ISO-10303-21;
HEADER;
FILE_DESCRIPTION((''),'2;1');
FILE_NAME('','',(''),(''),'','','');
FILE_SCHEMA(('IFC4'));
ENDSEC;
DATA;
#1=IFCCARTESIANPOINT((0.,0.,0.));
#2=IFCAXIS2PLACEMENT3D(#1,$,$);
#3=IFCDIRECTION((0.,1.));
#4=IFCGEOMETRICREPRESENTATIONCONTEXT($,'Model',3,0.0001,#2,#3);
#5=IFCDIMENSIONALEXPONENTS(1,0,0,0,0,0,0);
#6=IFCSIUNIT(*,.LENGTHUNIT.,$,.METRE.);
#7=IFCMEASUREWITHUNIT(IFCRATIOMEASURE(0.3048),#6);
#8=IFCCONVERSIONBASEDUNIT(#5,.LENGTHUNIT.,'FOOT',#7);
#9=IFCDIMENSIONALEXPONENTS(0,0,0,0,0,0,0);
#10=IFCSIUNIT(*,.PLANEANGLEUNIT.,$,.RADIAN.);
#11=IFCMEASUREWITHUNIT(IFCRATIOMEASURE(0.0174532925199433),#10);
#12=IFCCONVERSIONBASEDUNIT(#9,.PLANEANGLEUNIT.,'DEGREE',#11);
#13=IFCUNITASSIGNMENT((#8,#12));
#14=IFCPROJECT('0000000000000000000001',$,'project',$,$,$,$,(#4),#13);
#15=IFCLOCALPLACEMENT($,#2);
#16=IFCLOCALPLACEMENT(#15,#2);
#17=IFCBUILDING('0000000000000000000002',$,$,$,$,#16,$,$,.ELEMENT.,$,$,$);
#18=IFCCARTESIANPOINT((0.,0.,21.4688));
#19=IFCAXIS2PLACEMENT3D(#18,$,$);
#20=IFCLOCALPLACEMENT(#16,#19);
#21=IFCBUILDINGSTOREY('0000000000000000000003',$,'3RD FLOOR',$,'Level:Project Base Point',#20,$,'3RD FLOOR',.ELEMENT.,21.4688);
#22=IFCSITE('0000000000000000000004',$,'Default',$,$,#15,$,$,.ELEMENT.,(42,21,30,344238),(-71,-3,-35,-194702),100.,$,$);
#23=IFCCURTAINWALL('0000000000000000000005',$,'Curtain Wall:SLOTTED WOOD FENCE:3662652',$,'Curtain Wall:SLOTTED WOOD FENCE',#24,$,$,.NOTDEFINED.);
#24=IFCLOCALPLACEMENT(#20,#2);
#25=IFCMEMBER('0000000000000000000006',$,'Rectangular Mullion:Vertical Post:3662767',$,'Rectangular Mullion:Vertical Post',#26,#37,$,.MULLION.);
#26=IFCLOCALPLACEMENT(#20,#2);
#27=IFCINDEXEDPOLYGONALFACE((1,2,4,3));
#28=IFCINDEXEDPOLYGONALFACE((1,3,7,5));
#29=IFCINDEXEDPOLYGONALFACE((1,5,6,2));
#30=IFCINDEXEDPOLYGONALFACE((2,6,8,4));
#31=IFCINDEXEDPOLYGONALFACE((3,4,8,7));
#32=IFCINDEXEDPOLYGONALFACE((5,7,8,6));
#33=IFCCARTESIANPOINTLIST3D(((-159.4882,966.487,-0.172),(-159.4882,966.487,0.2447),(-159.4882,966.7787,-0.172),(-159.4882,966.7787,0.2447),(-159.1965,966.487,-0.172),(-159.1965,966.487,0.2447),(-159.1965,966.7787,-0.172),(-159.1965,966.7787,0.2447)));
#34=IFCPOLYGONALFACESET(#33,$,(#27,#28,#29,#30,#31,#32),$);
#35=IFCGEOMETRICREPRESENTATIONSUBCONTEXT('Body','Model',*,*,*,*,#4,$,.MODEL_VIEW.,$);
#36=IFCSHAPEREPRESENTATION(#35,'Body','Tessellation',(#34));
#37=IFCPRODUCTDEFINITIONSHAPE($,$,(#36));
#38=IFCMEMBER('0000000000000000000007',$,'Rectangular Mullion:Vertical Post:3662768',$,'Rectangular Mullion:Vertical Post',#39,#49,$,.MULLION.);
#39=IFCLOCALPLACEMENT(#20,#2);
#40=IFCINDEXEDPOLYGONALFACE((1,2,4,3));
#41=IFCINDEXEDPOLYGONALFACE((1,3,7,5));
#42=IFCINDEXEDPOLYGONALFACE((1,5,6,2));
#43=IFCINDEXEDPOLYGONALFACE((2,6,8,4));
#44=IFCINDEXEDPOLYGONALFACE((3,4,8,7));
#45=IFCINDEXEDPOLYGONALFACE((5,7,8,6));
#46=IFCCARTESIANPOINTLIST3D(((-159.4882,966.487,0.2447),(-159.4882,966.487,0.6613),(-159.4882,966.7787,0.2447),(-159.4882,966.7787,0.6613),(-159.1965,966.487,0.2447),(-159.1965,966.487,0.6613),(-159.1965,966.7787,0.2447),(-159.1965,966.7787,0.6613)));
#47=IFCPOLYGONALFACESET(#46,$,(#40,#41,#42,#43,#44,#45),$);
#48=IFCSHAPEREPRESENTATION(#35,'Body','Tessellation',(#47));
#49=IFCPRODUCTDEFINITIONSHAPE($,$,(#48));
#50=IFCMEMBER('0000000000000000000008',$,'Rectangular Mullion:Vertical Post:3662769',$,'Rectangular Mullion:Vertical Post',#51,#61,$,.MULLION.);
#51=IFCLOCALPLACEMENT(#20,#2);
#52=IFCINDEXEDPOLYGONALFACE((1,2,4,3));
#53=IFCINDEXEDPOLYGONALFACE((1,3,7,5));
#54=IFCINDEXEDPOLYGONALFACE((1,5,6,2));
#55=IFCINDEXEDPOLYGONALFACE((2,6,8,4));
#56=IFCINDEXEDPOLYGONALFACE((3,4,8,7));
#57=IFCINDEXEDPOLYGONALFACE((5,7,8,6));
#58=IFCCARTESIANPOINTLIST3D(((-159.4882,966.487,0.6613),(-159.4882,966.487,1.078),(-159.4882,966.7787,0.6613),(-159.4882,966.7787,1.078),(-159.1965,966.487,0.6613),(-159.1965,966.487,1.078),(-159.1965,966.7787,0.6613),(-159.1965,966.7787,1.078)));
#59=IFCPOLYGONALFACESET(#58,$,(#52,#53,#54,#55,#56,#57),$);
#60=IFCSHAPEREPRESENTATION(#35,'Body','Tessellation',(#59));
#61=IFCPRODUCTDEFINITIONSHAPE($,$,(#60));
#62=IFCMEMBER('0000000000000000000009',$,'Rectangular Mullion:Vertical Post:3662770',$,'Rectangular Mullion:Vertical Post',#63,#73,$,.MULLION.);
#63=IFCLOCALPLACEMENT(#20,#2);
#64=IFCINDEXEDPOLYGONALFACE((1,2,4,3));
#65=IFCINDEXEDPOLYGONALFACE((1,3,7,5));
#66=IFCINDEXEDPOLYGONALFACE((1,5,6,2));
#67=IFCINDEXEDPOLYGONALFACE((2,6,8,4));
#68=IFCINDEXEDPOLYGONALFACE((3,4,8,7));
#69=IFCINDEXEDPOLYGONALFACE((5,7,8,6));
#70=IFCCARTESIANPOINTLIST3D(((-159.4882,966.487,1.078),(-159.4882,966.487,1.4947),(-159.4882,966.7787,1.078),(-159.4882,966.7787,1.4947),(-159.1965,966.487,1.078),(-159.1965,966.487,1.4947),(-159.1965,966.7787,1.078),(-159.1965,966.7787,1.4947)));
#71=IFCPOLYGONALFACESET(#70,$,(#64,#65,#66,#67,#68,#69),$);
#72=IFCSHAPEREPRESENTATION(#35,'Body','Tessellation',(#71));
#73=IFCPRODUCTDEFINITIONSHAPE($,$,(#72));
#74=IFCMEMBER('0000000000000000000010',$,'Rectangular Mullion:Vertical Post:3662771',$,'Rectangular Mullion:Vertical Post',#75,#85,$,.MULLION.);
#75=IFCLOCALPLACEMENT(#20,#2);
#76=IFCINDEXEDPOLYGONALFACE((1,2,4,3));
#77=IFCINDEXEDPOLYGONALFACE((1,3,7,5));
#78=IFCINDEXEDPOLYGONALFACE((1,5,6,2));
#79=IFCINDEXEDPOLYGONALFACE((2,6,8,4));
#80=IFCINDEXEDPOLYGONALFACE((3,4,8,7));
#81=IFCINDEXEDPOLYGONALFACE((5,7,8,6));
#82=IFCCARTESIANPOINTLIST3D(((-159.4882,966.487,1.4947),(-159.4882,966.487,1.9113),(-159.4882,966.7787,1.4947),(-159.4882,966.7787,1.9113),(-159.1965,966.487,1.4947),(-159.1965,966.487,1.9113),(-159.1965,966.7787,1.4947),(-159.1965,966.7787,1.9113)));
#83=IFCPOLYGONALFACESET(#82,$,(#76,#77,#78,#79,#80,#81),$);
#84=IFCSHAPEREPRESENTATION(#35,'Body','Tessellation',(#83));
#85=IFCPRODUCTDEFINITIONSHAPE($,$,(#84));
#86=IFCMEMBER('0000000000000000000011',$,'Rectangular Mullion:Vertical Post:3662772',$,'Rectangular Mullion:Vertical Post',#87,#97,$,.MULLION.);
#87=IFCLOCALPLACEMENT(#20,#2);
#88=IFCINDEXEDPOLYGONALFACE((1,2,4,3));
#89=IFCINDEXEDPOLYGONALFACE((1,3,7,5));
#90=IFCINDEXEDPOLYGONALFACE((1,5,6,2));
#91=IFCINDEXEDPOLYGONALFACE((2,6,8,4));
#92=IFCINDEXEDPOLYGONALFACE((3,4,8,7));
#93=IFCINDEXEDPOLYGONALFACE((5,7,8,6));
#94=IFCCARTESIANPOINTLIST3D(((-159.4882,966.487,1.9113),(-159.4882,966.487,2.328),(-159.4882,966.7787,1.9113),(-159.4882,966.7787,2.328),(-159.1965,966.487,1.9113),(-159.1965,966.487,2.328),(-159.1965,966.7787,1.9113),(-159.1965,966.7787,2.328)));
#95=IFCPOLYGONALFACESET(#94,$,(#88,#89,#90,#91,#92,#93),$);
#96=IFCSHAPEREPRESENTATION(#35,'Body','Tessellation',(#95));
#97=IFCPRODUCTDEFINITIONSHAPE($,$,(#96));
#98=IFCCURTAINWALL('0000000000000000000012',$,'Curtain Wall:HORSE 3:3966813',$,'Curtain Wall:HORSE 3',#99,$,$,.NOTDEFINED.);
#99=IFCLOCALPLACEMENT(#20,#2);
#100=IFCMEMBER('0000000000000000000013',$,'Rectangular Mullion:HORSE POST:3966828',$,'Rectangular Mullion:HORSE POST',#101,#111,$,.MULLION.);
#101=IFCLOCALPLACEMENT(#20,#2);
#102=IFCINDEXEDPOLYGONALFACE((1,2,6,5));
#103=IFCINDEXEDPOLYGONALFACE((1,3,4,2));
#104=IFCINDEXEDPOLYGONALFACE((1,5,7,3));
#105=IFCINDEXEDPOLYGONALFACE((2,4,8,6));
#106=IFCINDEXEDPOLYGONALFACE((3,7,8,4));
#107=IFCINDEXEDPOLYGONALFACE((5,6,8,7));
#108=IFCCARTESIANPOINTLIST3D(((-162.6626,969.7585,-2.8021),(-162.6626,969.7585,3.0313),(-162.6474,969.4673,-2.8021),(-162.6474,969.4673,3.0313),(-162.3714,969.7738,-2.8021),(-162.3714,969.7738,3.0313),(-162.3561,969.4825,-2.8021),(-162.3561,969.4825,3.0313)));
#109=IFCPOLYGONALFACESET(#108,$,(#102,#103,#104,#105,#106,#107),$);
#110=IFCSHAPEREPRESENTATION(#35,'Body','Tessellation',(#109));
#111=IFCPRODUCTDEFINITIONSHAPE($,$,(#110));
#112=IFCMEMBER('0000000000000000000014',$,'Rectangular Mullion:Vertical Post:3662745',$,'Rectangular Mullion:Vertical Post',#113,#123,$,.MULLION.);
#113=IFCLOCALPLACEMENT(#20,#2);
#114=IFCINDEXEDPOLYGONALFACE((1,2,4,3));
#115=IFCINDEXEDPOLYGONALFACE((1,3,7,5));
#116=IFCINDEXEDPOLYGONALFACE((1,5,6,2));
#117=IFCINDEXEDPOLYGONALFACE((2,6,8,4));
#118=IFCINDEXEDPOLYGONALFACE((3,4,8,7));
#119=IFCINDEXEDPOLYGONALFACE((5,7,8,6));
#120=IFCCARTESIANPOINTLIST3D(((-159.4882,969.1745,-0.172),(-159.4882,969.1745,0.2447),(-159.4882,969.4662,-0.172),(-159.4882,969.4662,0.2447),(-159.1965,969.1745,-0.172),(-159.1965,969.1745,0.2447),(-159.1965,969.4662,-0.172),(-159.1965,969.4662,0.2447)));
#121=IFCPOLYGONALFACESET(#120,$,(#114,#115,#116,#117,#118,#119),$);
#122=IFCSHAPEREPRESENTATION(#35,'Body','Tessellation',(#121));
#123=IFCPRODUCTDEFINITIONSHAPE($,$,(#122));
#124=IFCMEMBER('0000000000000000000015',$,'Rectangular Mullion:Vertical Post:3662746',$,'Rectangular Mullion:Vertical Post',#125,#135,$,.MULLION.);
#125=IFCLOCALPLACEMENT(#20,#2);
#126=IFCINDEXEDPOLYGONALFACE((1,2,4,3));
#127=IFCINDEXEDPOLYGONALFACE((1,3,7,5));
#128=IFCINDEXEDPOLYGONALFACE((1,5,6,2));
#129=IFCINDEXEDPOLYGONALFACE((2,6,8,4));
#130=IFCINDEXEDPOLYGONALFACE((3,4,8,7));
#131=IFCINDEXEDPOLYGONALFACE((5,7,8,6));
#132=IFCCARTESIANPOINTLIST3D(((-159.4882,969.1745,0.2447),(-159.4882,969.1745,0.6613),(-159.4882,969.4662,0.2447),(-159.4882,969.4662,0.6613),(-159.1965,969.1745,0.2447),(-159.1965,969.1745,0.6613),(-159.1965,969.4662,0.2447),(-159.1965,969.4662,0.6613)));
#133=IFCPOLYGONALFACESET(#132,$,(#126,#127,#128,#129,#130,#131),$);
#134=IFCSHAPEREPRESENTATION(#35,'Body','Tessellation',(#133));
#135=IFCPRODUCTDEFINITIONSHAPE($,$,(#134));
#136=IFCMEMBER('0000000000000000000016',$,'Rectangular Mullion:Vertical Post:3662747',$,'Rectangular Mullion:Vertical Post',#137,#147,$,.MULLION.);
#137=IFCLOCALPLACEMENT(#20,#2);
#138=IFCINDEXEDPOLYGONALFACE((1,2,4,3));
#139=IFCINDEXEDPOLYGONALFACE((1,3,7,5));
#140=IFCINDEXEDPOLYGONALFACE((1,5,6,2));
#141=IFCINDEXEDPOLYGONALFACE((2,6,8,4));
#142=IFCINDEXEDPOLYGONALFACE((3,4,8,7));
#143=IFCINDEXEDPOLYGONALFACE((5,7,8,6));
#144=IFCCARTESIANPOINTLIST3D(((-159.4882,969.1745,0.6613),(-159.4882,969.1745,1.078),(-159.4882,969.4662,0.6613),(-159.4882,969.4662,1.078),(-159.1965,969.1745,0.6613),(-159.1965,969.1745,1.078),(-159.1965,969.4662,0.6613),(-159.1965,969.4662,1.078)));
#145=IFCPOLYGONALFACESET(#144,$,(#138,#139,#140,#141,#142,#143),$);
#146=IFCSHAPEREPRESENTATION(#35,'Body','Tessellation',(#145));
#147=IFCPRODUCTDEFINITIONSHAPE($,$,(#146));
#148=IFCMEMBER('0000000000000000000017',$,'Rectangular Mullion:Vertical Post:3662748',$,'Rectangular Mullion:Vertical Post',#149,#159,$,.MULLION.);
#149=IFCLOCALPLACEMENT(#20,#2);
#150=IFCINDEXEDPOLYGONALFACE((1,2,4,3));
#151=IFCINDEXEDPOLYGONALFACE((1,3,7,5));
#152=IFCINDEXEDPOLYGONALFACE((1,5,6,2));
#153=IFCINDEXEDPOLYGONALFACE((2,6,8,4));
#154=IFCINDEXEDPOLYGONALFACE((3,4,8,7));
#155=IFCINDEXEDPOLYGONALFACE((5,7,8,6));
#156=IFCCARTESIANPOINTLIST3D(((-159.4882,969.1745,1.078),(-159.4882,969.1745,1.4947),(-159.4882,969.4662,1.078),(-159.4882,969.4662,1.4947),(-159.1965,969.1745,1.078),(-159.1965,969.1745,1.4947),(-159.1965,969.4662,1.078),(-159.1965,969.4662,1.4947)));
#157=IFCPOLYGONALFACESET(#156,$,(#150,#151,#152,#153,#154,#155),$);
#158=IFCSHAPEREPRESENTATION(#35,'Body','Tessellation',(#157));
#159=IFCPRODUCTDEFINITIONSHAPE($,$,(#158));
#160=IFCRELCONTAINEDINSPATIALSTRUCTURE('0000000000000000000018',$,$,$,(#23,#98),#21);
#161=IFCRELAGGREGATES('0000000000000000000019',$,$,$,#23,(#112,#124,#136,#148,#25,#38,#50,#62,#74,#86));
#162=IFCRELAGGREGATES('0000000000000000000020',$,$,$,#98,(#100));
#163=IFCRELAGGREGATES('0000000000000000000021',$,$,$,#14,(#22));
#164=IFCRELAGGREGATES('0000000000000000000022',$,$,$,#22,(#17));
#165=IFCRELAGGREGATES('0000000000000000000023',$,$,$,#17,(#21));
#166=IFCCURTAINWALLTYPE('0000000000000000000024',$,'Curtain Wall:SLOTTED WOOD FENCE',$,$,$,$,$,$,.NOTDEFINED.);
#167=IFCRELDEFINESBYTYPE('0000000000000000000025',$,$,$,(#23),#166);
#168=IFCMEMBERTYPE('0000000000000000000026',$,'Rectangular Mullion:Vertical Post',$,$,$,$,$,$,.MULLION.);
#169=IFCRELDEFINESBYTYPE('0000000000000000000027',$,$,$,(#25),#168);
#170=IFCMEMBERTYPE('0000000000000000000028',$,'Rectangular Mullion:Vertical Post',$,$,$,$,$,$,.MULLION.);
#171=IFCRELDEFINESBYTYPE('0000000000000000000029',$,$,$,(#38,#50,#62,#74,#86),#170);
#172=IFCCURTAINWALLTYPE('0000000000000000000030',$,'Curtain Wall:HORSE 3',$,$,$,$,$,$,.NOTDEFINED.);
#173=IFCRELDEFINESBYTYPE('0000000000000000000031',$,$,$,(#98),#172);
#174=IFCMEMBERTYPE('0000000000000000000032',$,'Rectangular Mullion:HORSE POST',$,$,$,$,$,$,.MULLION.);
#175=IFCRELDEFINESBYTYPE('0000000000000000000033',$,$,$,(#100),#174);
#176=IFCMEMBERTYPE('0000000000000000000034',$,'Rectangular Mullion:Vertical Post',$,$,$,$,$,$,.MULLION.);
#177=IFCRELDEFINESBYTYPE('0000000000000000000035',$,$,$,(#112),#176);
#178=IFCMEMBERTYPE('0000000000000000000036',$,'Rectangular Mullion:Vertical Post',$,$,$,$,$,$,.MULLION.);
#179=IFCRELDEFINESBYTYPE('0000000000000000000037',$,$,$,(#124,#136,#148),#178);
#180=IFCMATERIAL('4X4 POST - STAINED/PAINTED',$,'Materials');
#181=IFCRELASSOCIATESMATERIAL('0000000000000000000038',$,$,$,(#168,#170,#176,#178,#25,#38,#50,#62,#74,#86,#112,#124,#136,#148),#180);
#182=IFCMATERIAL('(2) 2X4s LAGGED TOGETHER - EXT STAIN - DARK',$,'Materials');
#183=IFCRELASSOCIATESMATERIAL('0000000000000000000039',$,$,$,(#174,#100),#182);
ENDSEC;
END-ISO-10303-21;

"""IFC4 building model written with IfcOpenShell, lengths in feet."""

from ifc_helpers import new_model, entity, si_unit, converted_unit, direction, frame, frame_2d, origin, origin_2d_with_axis, place, context, subcontext, project, spatial, rectangle, extrude, source, transform, mapped, material, material_profile, profile_set, profile_usage, type_object, type_shapes, element, aggregate, save


model = new_model("IFC4")

# Units and contexts
model_context = context("Model", 3, precision=0.0001, world=origin(), true_north=direction((0.0, 1.0)))
body_context = subcontext(model_context, "Body", "Model", "MODEL_VIEW")
ifc_project = project(units=[converted_unit("LENGTHUNIT", "FOOT", entity("IfcRatioMeasure", 0.3048), si_unit("LENGTHUNIT", "METRE"), dimensions=[1, 0, 0, 0, 0, 0, 0]), converted_unit("PLANEANGLEUNIT", "DEGREE", entity("IfcRatioMeasure", 0.0174532925199433), si_unit("PLANEANGLEUNIT", "RADIAN"), dimensions=[0, 0, 0, 0, 0, 0, 0])], contexts=[model_context])

# Site, building, storey
site_placement = place(None, origin())
site = spatial("IfcSite", under=ifc_project, at=site_placement, Name="Default", CompositionType="ELEMENT", RefLatitude=(42, 21, 30, 344238), RefLongitude=(-71, -3, -35, -194702), RefElevation=100.0)
building_placement = place(site_placement, origin())
building = spatial("IfcBuilding", under=site, at=building_placement, CompositionType="ELEMENT")
storey_placement = place(building_placement, frame((0.0, 0.0, 21.4688)))
storey = spatial("IfcBuildingStorey", under=building, at=storey_placement, Name="3RD FLOOR", ObjectType="Level:Project Base Point", LongName="3RD FLOOR", CompositionType="ELEMENT", Elevation=21.4688)

# Curtain wall, members
curtain_wall_type_1 = type_object("IfcCurtainWallType", Name="Curtain Wall:SLOTTED WOOD FENCE", PredefinedType="NOTDEFINED")
curtain_wall_1_placement = place(storey_placement, frame((0.0, 0.0, -21.4688)))
curtain_wall_1 = element("IfcCurtainWall", 1, at=curtain_wall_1_placement, inside=storey, type_object=curtain_wall_type_1, Name="Curtain Wall:SLOTTED WOOD FENCE:3662652", ObjectType="Curtain Wall:SLOTTED WOOD FENCE", PredefinedType="NOTDEFINED")
ifc_material_1 = material(Name="4X4 POST - STAINED/PAINTED", Category="Materials")
ifc_material_profile_1 = material_profile(ifc_material_1, rectangle(XDim=0.2917, YDim=0.2917, at=origin_2d_with_axis()), Name="Vertical Post")
ifc_profile_set_1 = profile_set([ifc_material_profile_1], Name="Vertical Post")
ifc_profile_usage_1 = profile_usage(ifc_profile_set_1)
member_type_1 = type_object("IfcMemberType", Name="Rectangular Mullion:Vertical Post", PredefinedType="MULLION", material=ifc_profile_set_1)
shared_shape_1 = source(origin(), body_context, "Body", "SweptSolid", [
    extrude(rectangle(XDim=0.2917, YDim=0.2917, at=origin_2d_with_axis()), frame((0.0, -0.2083, -0.4167), z_axis=(0.0, 0.0, 1.0), x_axis=(0.0, -1.0, 0.0)), (0.0, 0.0, 1.0), 0.4167),
])
type_shapes(member_type_1, [shared_shape_1])
member_1_placement = place(storey_placement, frame((-159.5507, 966.6328, -0.172), z_axis=(0.0, 0.0, -1.0), x_axis=(0.0, -1.0, 0.0)))
member_1 = element("IfcMember", 2, at=member_1_placement, type_object=member_type_1, material=ifc_profile_usage_1, Name="Rectangular Mullion:Vertical Post:3662767", ObjectType="Rectangular Mullion:Vertical Post", PredefinedType="MULLION", context=body_context, shape_type="MappedRepresentation", body=[
    mapped(shared_shape_1, transform((0.0, 0.0, 0.0), scale=1.0)),
])
ifc_profile_usage_2 = profile_usage(ifc_profile_set_1)
member_type_2 = type_object("IfcMemberType", Name="Rectangular Mullion:Vertical Post", PredefinedType="MULLION", material=ifc_profile_set_1)
shared_shape_2 = source(origin(), body_context, "Body", "SweptSolid", [
    extrude(rectangle(XDim=0.2917, YDim=0.2917, at=origin_2d_with_axis()), frame((0.0, -0.2083, -0.4167), z_axis=(0.0, 0.0, 1.0), x_axis=(0.0, -1.0, 0.0)), (0.0, 0.0, 1.0), 0.4167),
])
type_shapes(member_type_2, [shared_shape_2])
member_2_placement = place(storey_placement, frame((-159.5507, 966.6328, 0.2447), z_axis=(0.0, 0.0, -1.0), x_axis=(0.0, -1.0, 0.0)))
member_2 = element("IfcMember", 3, at=member_2_placement, type_object=member_type_2, material=ifc_profile_usage_2, Name="Rectangular Mullion:Vertical Post:3662768", ObjectType="Rectangular Mullion:Vertical Post", PredefinedType="MULLION", context=body_context, shape_type="MappedRepresentation", body=[
    mapped(shared_shape_2, transform((0.0, 0.0, 0.0), scale=1.0)),
])
ifc_profile_usage_3 = profile_usage(ifc_profile_set_1)
member_3_placement = place(storey_placement, frame((-159.5507, 966.6328, 0.6613), z_axis=(0.0, 0.0, -1.0), x_axis=(0.0, -1.0, 0.0)))
member_3 = element("IfcMember", 4, at=member_3_placement, type_object=member_type_2, material=ifc_profile_usage_3, Name="Rectangular Mullion:Vertical Post:3662769", ObjectType="Rectangular Mullion:Vertical Post", PredefinedType="MULLION", context=body_context, shape_type="MappedRepresentation", body=[
    mapped(shared_shape_2, transform((0.0, 0.0, 0.0), scale=1.0)),
])
ifc_profile_usage_4 = profile_usage(ifc_profile_set_1)
member_4_placement = place(storey_placement, frame((-159.5507, 966.6328, 1.078), z_axis=(0.0, 0.0, -1.0), x_axis=(0.0, -1.0, 0.0)))
member_4 = element("IfcMember", 5, at=member_4_placement, type_object=member_type_2, material=ifc_profile_usage_4, Name="Rectangular Mullion:Vertical Post:3662770", ObjectType="Rectangular Mullion:Vertical Post", PredefinedType="MULLION", context=body_context, shape_type="MappedRepresentation", body=[
    mapped(shared_shape_2, transform((0.0, 0.0, 0.0), scale=1.0)),
])
ifc_profile_usage_5 = profile_usage(ifc_profile_set_1)
member_5_placement = place(storey_placement, frame((-159.5507, 966.6328, 1.4947), z_axis=(0.0, 0.0, -1.0), x_axis=(0.0, -1.0, 0.0)))
member_5 = element("IfcMember", 6, at=member_5_placement, type_object=member_type_2, material=ifc_profile_usage_5, Name="Rectangular Mullion:Vertical Post:3662771", ObjectType="Rectangular Mullion:Vertical Post", PredefinedType="MULLION", context=body_context, shape_type="MappedRepresentation", body=[
    mapped(shared_shape_2, transform((0.0, 0.0, 0.0), scale=1.0)),
])
ifc_profile_usage_6 = profile_usage(ifc_profile_set_1)
member_6_placement = place(storey_placement, frame((-159.5507, 966.6328, 1.9113), z_axis=(0.0, 0.0, -1.0), x_axis=(0.0, -1.0, 0.0)))
member_6 = element("IfcMember", 7, at=member_6_placement, type_object=member_type_2, material=ifc_profile_usage_6, Name="Rectangular Mullion:Vertical Post:3662772", ObjectType="Rectangular Mullion:Vertical Post", PredefinedType="MULLION", context=body_context, shape_type="MappedRepresentation", body=[
    mapped(shared_shape_2, transform((0.0, 0.0, 0.0), scale=1.0)),
])

# Curtain wall, member
curtain_wall_type_2 = type_object("IfcCurtainWallType", Name="Curtain Wall:HORSE 3", PredefinedType="NOTDEFINED")
curtain_wall_2_placement = place(storey_placement, frame((0.0, 0.0, -21.4688)))
curtain_wall_2 = element("IfcCurtainWall", 8, at=curtain_wall_2_placement, inside=storey, type_object=curtain_wall_type_2, Name="Curtain Wall:HORSE 3:3966813", ObjectType="Curtain Wall:HORSE 3", PredefinedType="NOTDEFINED")
ifc_material_2 = material(Name="(2) 2X4s LAGGED TOGETHER - EXT STAIN - DARK", Category="Materials")
ifc_material_profile_2 = material_profile(ifc_material_2, rectangle(XDim=0.2917, YDim=0.2917, at=frame_2d((0.0, 0.0), x_axis=(1.0, 0.0))), Name="HORSE POST")
ifc_profile_set_2 = profile_set([ifc_material_profile_2], Name="HORSE POST")
ifc_profile_usage_7 = profile_usage(ifc_profile_set_2)
member_type_3 = type_object("IfcMemberType", Name="Rectangular Mullion:HORSE POST", PredefinedType="MULLION", material=ifc_profile_set_2)
shared_shape_3 = source(origin(), body_context, "Body", "SweptSolid", [
    extrude(rectangle(XDim=0.2917, YDim=0.2917, at=origin_2d_with_axis()), frame((0.0, 0.1458, -5.8333), z_axis=(0.0, 0.0, 1.0), x_axis=(0.0, -1.0, 0.0)), (0.0, 0.0, 1.0), 5.8333),
])
type_shapes(member_type_3, [shared_shape_3])
member_7_placement = place(storey_placement, frame((-162.5017, 969.4749, -2.8021), z_axis=(0.0, 0.0, -1.0), x_axis=(-0.99863, -0.052336, 0.0)))
member_7 = element("IfcMember", 9, at=member_7_placement, type_object=member_type_3, material=ifc_profile_usage_7, Name="Rectangular Mullion:HORSE POST:3966828", ObjectType="Rectangular Mullion:HORSE POST", PredefinedType="MULLION", context=body_context, shape_type="MappedRepresentation", body=[
    mapped(shared_shape_3, transform((0.0, 0.0, 0.0), scale=1.0)),
])

# Members
ifc_profile_usage_8 = profile_usage(ifc_profile_set_1)
member_type_4 = type_object("IfcMemberType", Name="Rectangular Mullion:Vertical Post", PredefinedType="MULLION", material=ifc_profile_set_1)
shared_shape_4 = source(origin(), body_context, "Body", "SweptSolid", [
    extrude(rectangle(XDim=0.2917, YDim=0.2917, at=origin_2d_with_axis()), frame((-0.1458, -0.2083, -0.4167), z_axis=(0.0, 0.0, 1.0), x_axis=(0.0, -1.0, 0.0)), (0.0, 0.0, 1.0), 0.4167),
])
type_shapes(member_type_4, [shared_shape_4])
member_8_placement = place(storey_placement, frame((-159.5507, 969.4662, 0.2447), z_axis=(0.0, 0.0, 1.0), x_axis=(0.0, 1.0, 0.0)))
member_8 = element("IfcMember", 10, at=member_8_placement, type_object=member_type_4, material=ifc_profile_usage_8, Name="Rectangular Mullion:Vertical Post:3662745", ObjectType="Rectangular Mullion:Vertical Post", PredefinedType="MULLION", context=body_context, shape_type="MappedRepresentation", body=[
    mapped(shared_shape_4, transform((0.0, 0.0, 0.0), scale=1.0)),
])
ifc_profile_usage_9 = profile_usage(ifc_profile_set_1)
member_type_5 = type_object("IfcMemberType", Name="Rectangular Mullion:Vertical Post", PredefinedType="MULLION", material=ifc_profile_set_1)
shared_shape_5 = source(origin(), body_context, "Body", "SweptSolid", [
    extrude(rectangle(XDim=0.2917, YDim=0.2917, at=origin_2d_with_axis()), frame((-0.1458, -0.2083, -0.4167), z_axis=(0.0, 0.0, 1.0), x_axis=(0.0, -1.0, 0.0)), (0.0, 0.0, 1.0), 0.4167),
])
type_shapes(member_type_5, [shared_shape_5])
member_9_placement = place(storey_placement, frame((-159.5507, 969.4662, 0.6613), z_axis=(0.0, 0.0, 1.0), x_axis=(0.0, 1.0, 0.0)))
member_9 = element("IfcMember", 11, at=member_9_placement, type_object=member_type_5, material=ifc_profile_usage_9, Name="Rectangular Mullion:Vertical Post:3662746", ObjectType="Rectangular Mullion:Vertical Post", PredefinedType="MULLION", context=body_context, shape_type="MappedRepresentation", body=[
    mapped(shared_shape_5, transform((0.0, 0.0, 0.0), scale=1.0)),
])
ifc_profile_usage_10 = profile_usage(ifc_profile_set_1)
member_10_placement = place(storey_placement, frame((-159.5507, 969.4662, 1.078), z_axis=(0.0, 0.0, 1.0), x_axis=(0.0, 1.0, 0.0)))
member_10 = element("IfcMember", 12, at=member_10_placement, type_object=member_type_5, material=ifc_profile_usage_10, Name="Rectangular Mullion:Vertical Post:3662747", ObjectType="Rectangular Mullion:Vertical Post", PredefinedType="MULLION", context=body_context, shape_type="MappedRepresentation", body=[
    mapped(shared_shape_5, transform((0.0, 0.0, 0.0), scale=1.0)),
])
ifc_profile_usage_11 = profile_usage(ifc_profile_set_1)
member_11_placement = place(storey_placement, frame((-159.5507, 969.4662, 1.4947), z_axis=(0.0, 0.0, 1.0), x_axis=(0.0, 1.0, 0.0)))
member_11 = element("IfcMember", 13, at=member_11_placement, type_object=member_type_5, material=ifc_profile_usage_11, Name="Rectangular Mullion:Vertical Post:3662748", ObjectType="Rectangular Mullion:Vertical Post", PredefinedType="MULLION", context=body_context, shape_type="MappedRepresentation", body=[
    mapped(shared_shape_5, transform((0.0, 0.0, 0.0), scale=1.0)),
])

aggregate(curtain_wall_1, [member_8, member_9, member_10, member_11, member_1, member_2, member_3, member_4, member_5, member_6])
aggregate(curtain_wall_2, [member_7])

save(model, "model.ifc")
